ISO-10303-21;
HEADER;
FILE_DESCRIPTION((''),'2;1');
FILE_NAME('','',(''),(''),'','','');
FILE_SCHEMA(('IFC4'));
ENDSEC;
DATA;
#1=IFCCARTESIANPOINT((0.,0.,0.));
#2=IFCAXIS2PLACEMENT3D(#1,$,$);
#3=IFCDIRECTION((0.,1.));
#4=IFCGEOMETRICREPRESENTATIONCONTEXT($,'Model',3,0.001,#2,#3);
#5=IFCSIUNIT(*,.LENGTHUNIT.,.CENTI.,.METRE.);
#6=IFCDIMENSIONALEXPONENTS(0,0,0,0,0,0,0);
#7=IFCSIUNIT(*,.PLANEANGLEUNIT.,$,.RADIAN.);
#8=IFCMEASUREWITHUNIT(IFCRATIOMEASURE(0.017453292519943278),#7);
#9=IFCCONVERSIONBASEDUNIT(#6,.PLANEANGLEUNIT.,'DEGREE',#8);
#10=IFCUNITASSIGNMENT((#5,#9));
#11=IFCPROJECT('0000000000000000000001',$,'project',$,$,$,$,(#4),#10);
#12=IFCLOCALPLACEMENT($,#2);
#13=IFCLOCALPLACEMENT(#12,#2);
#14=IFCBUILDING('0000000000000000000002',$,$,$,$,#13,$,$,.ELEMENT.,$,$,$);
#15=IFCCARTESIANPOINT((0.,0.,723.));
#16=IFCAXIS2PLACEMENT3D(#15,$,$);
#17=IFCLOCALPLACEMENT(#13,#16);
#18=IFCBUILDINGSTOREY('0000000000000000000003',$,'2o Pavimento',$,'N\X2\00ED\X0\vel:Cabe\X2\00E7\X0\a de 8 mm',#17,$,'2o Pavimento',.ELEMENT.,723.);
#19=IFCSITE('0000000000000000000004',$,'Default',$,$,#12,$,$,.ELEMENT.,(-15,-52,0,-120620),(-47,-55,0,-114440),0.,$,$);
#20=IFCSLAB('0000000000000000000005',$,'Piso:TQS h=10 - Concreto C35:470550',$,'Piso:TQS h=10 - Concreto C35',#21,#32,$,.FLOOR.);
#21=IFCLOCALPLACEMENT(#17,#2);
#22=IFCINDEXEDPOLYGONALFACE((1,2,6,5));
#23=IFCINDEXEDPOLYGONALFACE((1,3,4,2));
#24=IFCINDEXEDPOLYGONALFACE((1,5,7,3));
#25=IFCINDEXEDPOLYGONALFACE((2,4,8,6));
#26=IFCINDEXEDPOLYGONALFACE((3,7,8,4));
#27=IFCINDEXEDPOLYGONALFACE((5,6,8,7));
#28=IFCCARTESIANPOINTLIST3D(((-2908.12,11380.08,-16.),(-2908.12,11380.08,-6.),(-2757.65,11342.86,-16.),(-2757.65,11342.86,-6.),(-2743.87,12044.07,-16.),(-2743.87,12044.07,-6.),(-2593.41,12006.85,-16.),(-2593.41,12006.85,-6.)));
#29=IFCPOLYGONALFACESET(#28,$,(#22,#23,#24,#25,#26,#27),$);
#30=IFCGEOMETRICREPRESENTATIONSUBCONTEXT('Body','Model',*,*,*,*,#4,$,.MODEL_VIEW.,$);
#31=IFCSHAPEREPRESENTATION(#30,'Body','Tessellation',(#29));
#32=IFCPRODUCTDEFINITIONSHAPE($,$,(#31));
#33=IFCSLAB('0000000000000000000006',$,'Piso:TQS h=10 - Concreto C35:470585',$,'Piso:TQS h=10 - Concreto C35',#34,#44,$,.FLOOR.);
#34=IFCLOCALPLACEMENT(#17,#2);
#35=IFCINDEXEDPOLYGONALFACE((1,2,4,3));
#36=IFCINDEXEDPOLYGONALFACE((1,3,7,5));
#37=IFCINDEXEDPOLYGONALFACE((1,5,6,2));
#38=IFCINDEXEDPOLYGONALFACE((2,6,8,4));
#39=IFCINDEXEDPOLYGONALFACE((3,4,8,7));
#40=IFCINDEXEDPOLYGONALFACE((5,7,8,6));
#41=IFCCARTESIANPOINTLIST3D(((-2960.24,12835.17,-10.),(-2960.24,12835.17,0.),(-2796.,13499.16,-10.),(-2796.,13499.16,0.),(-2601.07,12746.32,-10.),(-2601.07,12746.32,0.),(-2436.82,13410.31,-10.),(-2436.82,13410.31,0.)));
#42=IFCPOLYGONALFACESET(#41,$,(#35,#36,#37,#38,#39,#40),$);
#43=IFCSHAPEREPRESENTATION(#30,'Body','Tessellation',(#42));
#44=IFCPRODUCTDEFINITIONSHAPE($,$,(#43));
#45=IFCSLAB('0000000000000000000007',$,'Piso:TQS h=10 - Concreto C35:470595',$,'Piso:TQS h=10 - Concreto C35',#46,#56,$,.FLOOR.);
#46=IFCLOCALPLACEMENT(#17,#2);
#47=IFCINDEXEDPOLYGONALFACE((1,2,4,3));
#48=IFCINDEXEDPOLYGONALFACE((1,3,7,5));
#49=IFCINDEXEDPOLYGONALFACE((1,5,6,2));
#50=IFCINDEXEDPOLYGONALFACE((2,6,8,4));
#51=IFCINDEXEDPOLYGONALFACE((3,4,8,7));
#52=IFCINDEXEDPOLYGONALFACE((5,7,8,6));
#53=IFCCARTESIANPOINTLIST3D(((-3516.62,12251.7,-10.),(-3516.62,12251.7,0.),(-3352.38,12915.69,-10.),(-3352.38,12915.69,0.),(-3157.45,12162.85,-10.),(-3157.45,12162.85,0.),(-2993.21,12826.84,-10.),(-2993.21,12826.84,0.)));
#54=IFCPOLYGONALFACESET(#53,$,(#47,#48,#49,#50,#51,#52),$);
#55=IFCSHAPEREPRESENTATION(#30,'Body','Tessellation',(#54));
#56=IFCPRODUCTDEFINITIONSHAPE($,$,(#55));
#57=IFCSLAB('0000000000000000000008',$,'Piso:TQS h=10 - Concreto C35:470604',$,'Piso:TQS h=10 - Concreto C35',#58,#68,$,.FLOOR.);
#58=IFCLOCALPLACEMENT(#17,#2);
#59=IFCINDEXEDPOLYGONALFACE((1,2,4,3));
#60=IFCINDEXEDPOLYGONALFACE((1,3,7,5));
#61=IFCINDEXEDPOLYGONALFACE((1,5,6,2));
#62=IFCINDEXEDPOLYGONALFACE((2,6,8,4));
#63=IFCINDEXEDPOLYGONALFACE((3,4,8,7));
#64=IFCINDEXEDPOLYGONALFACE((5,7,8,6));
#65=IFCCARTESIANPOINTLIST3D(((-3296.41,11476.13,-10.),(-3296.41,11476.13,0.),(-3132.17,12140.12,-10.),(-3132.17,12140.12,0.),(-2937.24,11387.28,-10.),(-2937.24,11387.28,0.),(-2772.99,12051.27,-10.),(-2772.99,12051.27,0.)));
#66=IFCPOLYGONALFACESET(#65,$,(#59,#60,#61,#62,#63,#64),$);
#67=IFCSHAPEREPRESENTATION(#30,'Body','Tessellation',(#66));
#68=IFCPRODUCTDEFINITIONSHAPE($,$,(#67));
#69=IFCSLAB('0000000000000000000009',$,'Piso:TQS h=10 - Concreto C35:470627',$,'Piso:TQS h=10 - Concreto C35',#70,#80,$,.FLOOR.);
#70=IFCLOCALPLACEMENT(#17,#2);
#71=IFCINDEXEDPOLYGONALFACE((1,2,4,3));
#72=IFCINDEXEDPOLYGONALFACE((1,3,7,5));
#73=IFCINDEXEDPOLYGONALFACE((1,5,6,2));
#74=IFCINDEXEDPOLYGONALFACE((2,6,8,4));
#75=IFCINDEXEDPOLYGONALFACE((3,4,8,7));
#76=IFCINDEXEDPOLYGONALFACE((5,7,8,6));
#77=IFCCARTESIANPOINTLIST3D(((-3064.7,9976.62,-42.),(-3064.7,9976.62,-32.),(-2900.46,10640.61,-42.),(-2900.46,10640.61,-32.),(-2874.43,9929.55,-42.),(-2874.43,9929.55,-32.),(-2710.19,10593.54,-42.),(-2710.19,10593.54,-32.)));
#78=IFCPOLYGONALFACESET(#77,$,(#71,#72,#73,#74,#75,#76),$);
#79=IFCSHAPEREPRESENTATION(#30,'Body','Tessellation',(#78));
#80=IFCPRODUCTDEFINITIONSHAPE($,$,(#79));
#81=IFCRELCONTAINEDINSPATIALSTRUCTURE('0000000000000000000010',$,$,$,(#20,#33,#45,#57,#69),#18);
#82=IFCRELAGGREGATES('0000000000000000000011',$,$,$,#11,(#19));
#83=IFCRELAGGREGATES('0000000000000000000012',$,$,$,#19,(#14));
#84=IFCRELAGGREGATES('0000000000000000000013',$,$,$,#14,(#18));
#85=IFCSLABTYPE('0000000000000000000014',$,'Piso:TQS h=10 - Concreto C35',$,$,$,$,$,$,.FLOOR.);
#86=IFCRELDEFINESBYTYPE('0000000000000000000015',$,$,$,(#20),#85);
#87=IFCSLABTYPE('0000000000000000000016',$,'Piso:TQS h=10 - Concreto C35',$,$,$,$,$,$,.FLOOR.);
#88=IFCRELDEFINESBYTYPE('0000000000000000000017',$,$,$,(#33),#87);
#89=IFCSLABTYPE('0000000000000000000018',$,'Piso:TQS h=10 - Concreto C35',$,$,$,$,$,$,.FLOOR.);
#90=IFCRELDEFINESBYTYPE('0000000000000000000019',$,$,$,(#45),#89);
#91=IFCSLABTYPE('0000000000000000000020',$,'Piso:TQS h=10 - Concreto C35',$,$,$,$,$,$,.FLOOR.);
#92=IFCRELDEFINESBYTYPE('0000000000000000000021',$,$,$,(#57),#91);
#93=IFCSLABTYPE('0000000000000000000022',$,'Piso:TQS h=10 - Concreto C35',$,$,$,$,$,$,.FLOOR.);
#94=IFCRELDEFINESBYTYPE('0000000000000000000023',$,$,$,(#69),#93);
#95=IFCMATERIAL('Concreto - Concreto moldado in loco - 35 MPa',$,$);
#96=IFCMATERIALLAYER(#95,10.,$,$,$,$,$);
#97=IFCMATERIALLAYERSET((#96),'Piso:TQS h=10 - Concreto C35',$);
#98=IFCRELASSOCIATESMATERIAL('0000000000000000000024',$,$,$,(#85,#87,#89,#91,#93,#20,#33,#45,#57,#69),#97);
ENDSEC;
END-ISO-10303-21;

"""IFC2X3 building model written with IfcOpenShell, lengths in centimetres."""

from ifc_helpers import new_model, entity, si_unit, converted_unit, direction, frame, frame_2d, origin, place, context, subcontext, project, spatial, rectangle, extrude, material, layer, layer_set, layer_usage, type_object, element, save


model = new_model("IFC2X3")

# Units and contexts
model_context = context("Model", 3, precision=0.001, world=origin(), true_north=direction((0.0, 1.0)))
body_context = subcontext(model_context, "Body", "Model", "MODEL_VIEW")
ifc_project = project(units=[si_unit("LENGTHUNIT", "METRE", prefix="CENTI"), converted_unit("PLANEANGLEUNIT", "DEGREE", entity("IfcRatioMeasure", 0.017453292519943278), si_unit("PLANEANGLEUNIT", "RADIAN"), dimensions=[0, 0, 0, 0, 0, 0, 0])], contexts=[model_context])

# Site, building, storey
site_placement = place(None, origin())
site = spatial("IfcSite", under=ifc_project, at=site_placement, Name="Default", CompositionType="ELEMENT", RefLatitude=(-15, -52, 0, -120620), RefLongitude=(-47, -55, 0, -114440), RefElevation=0.0)
building_placement = place(site_placement, origin())
building = spatial("IfcBuilding", under=site, at=building_placement, CompositionType="ELEMENT")
storey_placement = place(building_placement, frame((0.0, 0.0, 723.0)))
storey = spatial("IfcBuildingStorey", under=building, at=storey_placement, Name="2o Pavimento", ObjectType="Nível:Cabeça de 8 mm", LongName="2o Pavimento", CompositionType="ELEMENT", Elevation=723.0)

# Shared definitions
ifc_material = material(Name="Concreto - Concreto moldado in loco - 35 MPa")

# Slabs
ifc_layer = layer(ifc_material, 10.0)
ifc_layer_set = layer_set([ifc_layer], Name="Piso:TQS h=10 - Concreto C35")
ifc_layer_usage_1 = layer_usage(ifc_layer_set, "AXIS3", "POSITIVE", 0.0)
slab_type_1 = type_object("IfcSlabType", Name="Piso:TQS h=10 - Concreto C35", PredefinedType="FLOOR", material=ifc_layer_set)
slab_1_placement = place(storey_placement, origin())
element("IfcSlab", 1, at=slab_1_placement, inside=storey, type_object=slab_type_1, material=ifc_layer_usage_1, Name="Piso:TQS h=10 - Concreto C35:470550", ObjectType="Piso:TQS h=10 - Concreto C35", PredefinedType="FLOOR", context=body_context, shape_type="SweptSolid", body=[
    extrude(rectangle(XDim=684.0, YDim=155.0, at=frame_2d((0.0, 0.0), x_axis=(1.0, 0.0))), frame((-2750.76, 11693.47, -6.0), z_axis=(0.0, 0.0, -1.0), x_axis=(-0.240122, -0.970743, 0.0)), (0.0, 0.0, 1.0), 10.0),
])
ifc_layer_usage_2 = layer_usage(ifc_layer_set, "AXIS3", "POSITIVE", 0.0)
slab_type_2 = type_object("IfcSlabType", Name="Piso:TQS h=10 - Concreto C35", PredefinedType="FLOOR", material=ifc_layer_set)
slab_2_placement = place(storey_placement, origin())
element("IfcSlab", 2, at=slab_2_placement, inside=storey, type_object=slab_type_2, material=ifc_layer_usage_2, Name="Piso:TQS h=10 - Concreto C35:470585", ObjectType="Piso:TQS h=10 - Concreto C35", PredefinedType="FLOOR", context=body_context, shape_type="SweptSolid", body=[
    extrude(rectangle(XDim=684.0, YDim=370.0, at=frame_2d((0.0, 0.0), x_axis=(1.0, 0.0))), frame((-2698.53, 13122.74, 0.0), z_axis=(0.0, 0.0, -1.0), x_axis=(-0.240122, -0.970743, 0.0)), (0.0, 0.0, 1.0), 10.0),
])
ifc_layer_usage_3 = layer_usage(ifc_layer_set, "AXIS3", "POSITIVE", 0.0)
slab_type_3 = type_object("IfcSlabType", Name="Piso:TQS h=10 - Concreto C35", PredefinedType="FLOOR", material=ifc_layer_set)
slab_3_placement = place(storey_placement, origin())
element("IfcSlab", 3, at=slab_3_placement, inside=storey, type_object=slab_type_3, material=ifc_layer_usage_3, Name="Piso:TQS h=10 - Concreto C35:470595", ObjectType="Piso:TQS h=10 - Concreto C35", PredefinedType="FLOOR", context=body_context, shape_type="SweptSolid", body=[
    extrude(rectangle(XDim=370.0, YDim=684.0, at=frame_2d((0.0, 0.0), x_axis=(1.0, 0.0))), frame((-3254.92, 12539.27, 0.0), z_axis=(0.0, 0.0, -1.0), x_axis=(0.970743, -0.240122, 0.0)), (0.0, 0.0, 1.0), 10.0),
])
ifc_layer_usage_4 = layer_usage(ifc_layer_set, "AXIS3", "POSITIVE", 0.0)
slab_type_4 = type_object("IfcSlabType", Name="Piso:TQS h=10 - Concreto C35", PredefinedType="FLOOR", material=ifc_layer_set)
slab_4_placement = place(storey_placement, origin())
element("IfcSlab", 4, at=slab_4_placement, inside=storey, type_object=slab_type_4, material=ifc_layer_usage_4, Name="Piso:TQS h=10 - Concreto C35:470604", ObjectType="Piso:TQS h=10 - Concreto C35", PredefinedType="FLOOR", context=body_context, shape_type="SweptSolid", body=[
    extrude(rectangle(XDim=684.0, YDim=370.0, at=frame_2d((0.0, 0.0), x_axis=(1.0, 0.0))), frame((-3034.7, 11763.7, 0.0), z_axis=(0.0, 0.0, -1.0), x_axis=(-0.240122, -0.970743, 0.0)), (0.0, 0.0, 1.0), 10.0),
])
ifc_layer_usage_5 = layer_usage(ifc_layer_set, "AXIS3", "POSITIVE", 0.0)
slab_type_5 = type_object("IfcSlabType", Name="Piso:TQS h=10 - Concreto C35", PredefinedType="FLOOR", material=ifc_layer_set)
slab_5_placement = place(storey_placement, origin())
element("IfcSlab", 5, at=slab_5_placement, inside=storey, type_object=slab_type_5, material=ifc_layer_usage_5, Name="Piso:TQS h=10 - Concreto C35:470627", ObjectType="Piso:TQS h=10 - Concreto C35", PredefinedType="FLOOR", context=body_context, shape_type="SweptSolid", body=[
    extrude(rectangle(XDim=684.0, YDim=196.0, at=frame_2d((0.0, 0.0), x_axis=(1.0, 0.0))), frame((-2887.44, 10285.08, -32.0), z_axis=(0.0, 0.0, -1.0), x_axis=(-0.240122, -0.970743, 0.0)), (0.0, 0.0, 1.0), 10.0),
])

save(model, "model.ifc")
